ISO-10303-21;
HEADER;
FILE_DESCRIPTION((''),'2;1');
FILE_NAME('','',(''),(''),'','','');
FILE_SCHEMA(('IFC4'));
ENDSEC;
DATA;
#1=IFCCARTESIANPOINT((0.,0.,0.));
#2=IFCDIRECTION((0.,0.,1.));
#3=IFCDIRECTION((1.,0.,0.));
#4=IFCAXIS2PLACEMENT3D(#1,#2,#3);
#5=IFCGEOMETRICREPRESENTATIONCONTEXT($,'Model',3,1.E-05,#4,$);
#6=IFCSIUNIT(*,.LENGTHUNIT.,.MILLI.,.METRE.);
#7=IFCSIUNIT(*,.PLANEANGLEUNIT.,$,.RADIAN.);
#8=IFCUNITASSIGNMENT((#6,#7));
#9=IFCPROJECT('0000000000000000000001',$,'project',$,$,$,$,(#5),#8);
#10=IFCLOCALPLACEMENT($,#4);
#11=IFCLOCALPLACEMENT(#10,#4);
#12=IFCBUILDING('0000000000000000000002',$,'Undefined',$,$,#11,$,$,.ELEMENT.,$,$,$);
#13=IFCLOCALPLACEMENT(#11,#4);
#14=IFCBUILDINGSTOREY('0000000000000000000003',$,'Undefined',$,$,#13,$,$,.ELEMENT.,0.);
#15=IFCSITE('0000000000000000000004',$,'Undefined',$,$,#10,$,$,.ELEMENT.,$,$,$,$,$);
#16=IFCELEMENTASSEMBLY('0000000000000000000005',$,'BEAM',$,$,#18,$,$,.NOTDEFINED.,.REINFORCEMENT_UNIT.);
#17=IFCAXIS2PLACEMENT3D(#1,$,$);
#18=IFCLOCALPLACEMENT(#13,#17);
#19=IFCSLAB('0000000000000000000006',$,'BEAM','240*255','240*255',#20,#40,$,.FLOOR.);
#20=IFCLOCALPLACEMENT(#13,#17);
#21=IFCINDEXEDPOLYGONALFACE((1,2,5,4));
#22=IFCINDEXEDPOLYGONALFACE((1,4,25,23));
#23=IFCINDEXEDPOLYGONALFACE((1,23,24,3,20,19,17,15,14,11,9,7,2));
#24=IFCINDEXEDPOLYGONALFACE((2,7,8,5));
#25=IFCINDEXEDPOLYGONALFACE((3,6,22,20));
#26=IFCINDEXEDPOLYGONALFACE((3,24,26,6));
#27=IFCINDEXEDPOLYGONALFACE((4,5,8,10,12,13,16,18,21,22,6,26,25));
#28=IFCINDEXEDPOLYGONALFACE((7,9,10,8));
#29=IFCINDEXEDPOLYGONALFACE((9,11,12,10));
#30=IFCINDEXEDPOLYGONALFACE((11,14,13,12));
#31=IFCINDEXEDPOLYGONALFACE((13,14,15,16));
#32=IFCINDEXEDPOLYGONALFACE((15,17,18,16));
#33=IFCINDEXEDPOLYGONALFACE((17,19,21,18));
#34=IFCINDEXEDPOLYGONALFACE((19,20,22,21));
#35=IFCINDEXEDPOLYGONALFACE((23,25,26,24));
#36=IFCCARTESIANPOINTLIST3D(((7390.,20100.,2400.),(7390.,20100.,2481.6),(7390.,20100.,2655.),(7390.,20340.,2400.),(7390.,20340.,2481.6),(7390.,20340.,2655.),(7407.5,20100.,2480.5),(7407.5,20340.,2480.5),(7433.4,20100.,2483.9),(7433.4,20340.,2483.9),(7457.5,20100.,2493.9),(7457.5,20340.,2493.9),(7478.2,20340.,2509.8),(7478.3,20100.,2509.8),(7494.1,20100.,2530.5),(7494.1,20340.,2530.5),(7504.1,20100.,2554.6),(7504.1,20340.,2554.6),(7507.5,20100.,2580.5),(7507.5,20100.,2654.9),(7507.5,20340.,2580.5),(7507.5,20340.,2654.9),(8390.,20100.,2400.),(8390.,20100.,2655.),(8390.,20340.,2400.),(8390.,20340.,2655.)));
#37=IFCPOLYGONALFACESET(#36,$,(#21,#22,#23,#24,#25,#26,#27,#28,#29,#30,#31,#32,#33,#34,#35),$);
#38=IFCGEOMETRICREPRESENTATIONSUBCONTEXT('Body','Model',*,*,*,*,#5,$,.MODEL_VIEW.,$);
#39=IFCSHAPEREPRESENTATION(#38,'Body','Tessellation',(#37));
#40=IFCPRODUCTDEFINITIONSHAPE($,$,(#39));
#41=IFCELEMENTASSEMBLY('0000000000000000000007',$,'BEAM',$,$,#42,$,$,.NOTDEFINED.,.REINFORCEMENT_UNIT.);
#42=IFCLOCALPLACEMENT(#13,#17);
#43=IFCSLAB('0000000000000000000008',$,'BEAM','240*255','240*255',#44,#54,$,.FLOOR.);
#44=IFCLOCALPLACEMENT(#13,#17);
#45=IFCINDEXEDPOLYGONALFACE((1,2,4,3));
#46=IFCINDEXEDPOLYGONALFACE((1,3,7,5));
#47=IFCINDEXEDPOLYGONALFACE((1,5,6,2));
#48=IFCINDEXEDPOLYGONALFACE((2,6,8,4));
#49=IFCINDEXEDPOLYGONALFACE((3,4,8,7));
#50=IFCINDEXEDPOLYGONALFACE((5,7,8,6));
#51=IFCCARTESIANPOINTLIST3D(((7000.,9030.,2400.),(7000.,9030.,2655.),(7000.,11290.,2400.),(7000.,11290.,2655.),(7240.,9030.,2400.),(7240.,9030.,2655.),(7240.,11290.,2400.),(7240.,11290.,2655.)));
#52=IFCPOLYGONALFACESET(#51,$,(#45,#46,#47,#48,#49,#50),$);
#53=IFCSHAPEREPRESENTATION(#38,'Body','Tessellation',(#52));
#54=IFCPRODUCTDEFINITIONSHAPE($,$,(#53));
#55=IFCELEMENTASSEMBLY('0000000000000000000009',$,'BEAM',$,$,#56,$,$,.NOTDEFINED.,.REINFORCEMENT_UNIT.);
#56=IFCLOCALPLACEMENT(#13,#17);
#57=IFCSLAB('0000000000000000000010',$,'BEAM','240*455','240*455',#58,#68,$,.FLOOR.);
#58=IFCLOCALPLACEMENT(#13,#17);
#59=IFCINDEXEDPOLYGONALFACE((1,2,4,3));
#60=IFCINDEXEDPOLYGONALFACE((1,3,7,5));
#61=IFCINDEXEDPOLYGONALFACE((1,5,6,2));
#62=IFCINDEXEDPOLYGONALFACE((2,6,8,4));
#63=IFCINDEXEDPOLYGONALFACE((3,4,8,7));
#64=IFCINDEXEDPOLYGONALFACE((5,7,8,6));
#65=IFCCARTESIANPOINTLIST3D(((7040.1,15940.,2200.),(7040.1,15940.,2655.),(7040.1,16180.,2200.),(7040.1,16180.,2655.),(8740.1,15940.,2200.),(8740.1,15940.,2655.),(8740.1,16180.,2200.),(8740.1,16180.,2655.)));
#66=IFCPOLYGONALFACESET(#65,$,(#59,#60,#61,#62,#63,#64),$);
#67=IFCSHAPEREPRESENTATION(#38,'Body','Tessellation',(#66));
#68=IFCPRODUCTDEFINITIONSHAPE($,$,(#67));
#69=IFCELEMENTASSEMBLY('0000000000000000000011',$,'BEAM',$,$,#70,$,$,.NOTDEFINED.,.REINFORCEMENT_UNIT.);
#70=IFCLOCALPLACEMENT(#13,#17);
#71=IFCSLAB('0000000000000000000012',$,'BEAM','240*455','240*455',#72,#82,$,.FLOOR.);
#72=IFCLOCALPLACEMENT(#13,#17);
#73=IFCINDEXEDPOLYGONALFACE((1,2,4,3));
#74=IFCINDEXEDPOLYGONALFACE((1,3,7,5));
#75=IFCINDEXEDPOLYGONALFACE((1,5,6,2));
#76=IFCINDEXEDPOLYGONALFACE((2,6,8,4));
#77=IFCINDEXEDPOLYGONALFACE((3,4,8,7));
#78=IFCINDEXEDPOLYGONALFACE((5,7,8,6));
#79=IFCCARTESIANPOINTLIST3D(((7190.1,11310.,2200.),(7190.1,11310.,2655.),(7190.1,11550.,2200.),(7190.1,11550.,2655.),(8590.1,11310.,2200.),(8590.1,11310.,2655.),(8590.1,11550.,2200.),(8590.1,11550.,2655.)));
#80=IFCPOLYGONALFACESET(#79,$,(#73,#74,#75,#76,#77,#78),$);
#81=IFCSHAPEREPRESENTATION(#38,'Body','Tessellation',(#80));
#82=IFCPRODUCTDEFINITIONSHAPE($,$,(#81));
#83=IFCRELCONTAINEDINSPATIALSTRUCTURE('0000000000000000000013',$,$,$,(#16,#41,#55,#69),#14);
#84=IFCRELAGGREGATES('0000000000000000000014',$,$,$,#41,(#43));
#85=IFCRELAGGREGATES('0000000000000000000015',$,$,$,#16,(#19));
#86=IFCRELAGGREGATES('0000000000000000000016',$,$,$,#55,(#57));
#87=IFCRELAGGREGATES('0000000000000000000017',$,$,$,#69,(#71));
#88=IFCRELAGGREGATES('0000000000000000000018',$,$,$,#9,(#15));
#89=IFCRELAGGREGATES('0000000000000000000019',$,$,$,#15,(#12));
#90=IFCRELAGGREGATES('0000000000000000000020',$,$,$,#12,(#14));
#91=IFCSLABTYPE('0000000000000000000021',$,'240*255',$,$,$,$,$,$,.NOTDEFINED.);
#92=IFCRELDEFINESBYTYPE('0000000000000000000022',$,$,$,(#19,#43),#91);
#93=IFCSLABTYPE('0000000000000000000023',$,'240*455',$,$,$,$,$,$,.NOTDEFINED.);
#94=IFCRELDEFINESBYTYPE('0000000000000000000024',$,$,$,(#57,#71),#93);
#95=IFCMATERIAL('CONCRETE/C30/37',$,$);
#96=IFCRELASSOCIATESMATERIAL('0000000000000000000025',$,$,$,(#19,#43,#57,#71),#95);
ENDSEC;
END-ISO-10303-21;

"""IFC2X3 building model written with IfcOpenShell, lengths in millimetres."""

from ifc_helpers import new_model, si_unit, frame, origin_with_axes, place, context, subcontext, project, spatial, polyline, outline, extrude, boolean, material, type_object, element, aggregate, save


model = new_model("IFC2X3")

# Units and contexts
model_context = context("Model", 3, precision=1e-05, world=origin_with_axes())
body_context = subcontext(model_context, "Body", "Model", "MODEL_VIEW")
ifc_project = project(units=[si_unit("LENGTHUNIT", "METRE", prefix="MILLI"), si_unit("PLANEANGLEUNIT", "RADIAN")], contexts=[model_context])

# Site, building, storey
site_placement = place(None, origin_with_axes())
site = spatial("IfcSite", under=ifc_project, at=site_placement, Name="Undefined", CompositionType="ELEMENT")
building_placement = place(site_placement, origin_with_axes())
building = spatial("IfcBuilding", under=site, at=building_placement, Name="Undefined", CompositionType="ELEMENT")
storey_placement = place(building_placement, origin_with_axes())
storey = spatial("IfcBuildingStorey", under=building, at=storey_placement, Name="Undefined", CompositionType="ELEMENT", Elevation=0.0)

# Element assemblies, slabs
assembly_1_placement = place(storey_placement, origin_with_axes())
assembly_1 = element("IfcElementAssembly", 1, at=assembly_1_placement, inside=storey, Name="BEAM", AssemblyPlace="NOTDEFINED", PredefinedType="REINFORCEMENT_UNIT")
ifc_material_1 = material(Name="CONCRETE/C30/37")
slab_type_1 = type_object("IfcSlabType", Name="240*255", PredefinedType="NOTDEFINED")
slab_1_placement = place(assembly_1_placement, frame((7390.0, 20220.0, 2400.0), z_axis=(0.0, 1.0, 0.0), x_axis=(0.0, 0.0, 1.0)))
slab_1 = element("IfcSlab", 2, at=slab_1_placement, type_object=slab_type_1, material=ifc_material_1, Name="BEAM", Description="240*255", ObjectType="240*255", PredefinedType="FLOOR", context=body_context, shape_type="CSG", body=[
    boolean("DIFFERENCE", extrude(outline(polyline([(0.0, 0.0), (255.0, 0.0), (255.0, 1000.0), (0.0, 1000.0), (0.0, 0.0)])), frame((0.0, 0.0, -120.0), z_axis=(0.0, 0.0, 1.0), x_axis=(1.0, 0.0, 0.0)), (0.0, 0.0, 1.0), 240.0), extrude(outline(polyline([(0.0, 0.0), (173.4, 0.0), (174.5, 17.5), (171.1, 43.4), (161.1, 67.5), (145.2, 88.3), (124.5, 104.1), (100.4, 114.1), (74.5, 117.5), (0.1, 117.5), (0.0, 0.0)])), frame((255.0, 0.0, 125.0), z_axis=(-0.000017, 0.000025, -1.0), x_axis=(-1.0, 0.000002, 0.000017)), (0.0, 0.0, 1.0), 250.0)),
])
assembly_2_placement = place(storey_placement, origin_with_axes())
assembly_2 = element("IfcElementAssembly", 3, at=assembly_2_placement, inside=storey, Name="BEAM", AssemblyPlace="NOTDEFINED", PredefinedType="REINFORCEMENT_UNIT")
slab_2_placement = place(assembly_2_placement, frame((7120.0, 11290.0, 2400.0), z_axis=(1.0, 0.0, 0.0), x_axis=(0.0, 0.0, 1.0)))
slab_2 = element("IfcSlab", 4, at=slab_2_placement, type_object=slab_type_1, material=ifc_material_1, Name="BEAM", Description="240*255", ObjectType="240*255", PredefinedType="FLOOR", context=body_context, shape_type="SweptSolid", body=[
    extrude(outline(polyline([(0.0, 0.0), (255.0, 0.0), (255.0, 2260.0), (0.0, 2260.0), (0.0, 0.0)])), frame((0.0, 0.0, -120.0), z_axis=(0.0, 0.0, 1.0), x_axis=(1.0, 0.0, 0.0)), (0.0, 0.0, 1.0), 240.0),
])
aggregate(assembly_2, [slab_2])
assembly_3_placement = place(storey_placement, origin_with_axes())
assembly_3 = element("IfcElementAssembly", 5, at=assembly_3_placement, inside=storey, Name="BEAM", AssemblyPlace="NOTDEFINED", PredefinedType="REINFORCEMENT_UNIT")
slab_type_2 = type_object("IfcSlabType", Name="240*455", PredefinedType="NOTDEFINED")
slab_3_placement = place(assembly_3_placement, frame((7040.1, 16060.0, 2200.0), z_axis=(0.0, 1.0, 0.0), x_axis=(0.0, 0.0, 1.0)))
slab_3 = element("IfcSlab", 6, at=slab_3_placement, type_object=slab_type_2, material=ifc_material_1, Name="BEAM", Description="240*455", ObjectType="240*455", PredefinedType="FLOOR", context=body_context, shape_type="SweptSolid", body=[
    extrude(outline(polyline([(0.0, 0.0), (455.0, 0.0), (455.0, 1700.0), (0.0, 1700.0), (0.0, 0.0)])), frame((0.0, 0.0, -120.0), z_axis=(0.0, 0.0, 1.0), x_axis=(1.0, 0.0, 0.0)), (0.0, 0.0, 1.0), 240.0),
])
assembly_4_placement = place(storey_placement, origin_with_axes())
assembly_4 = element("IfcElementAssembly", 7, at=assembly_4_placement, inside=storey, Name="BEAM", AssemblyPlace="NOTDEFINED", PredefinedType="REINFORCEMENT_UNIT")
slab_4_placement = place(assembly_4_placement, frame((7190.1, 11430.0, 2200.0), z_axis=(0.0, 1.0, 0.0), x_axis=(0.0, 0.0, 1.0)))
slab_4 = element("IfcSlab", 8, at=slab_4_placement, type_object=slab_type_2, material=ifc_material_1, Name="BEAM", Description="240*455", ObjectType="240*455", PredefinedType="FLOOR", context=body_context, shape_type="SweptSolid", body=[
    extrude(outline(polyline([(0.0, 0.0), (455.0, 0.0), (455.0, 1400.0), (0.0, 1400.0), (0.0, 0.0)])), frame((0.0, 0.0, -120.0), z_axis=(0.0, 0.0, 1.0), x_axis=(1.0, 0.0, 0.0)), (0.0, 0.0, 1.0), 240.0),
])

aggregate(assembly_1, [slab_1])
aggregate(assembly_3, [slab_3])
aggregate(assembly_4, [slab_4])

save(model, "model.ifc")
